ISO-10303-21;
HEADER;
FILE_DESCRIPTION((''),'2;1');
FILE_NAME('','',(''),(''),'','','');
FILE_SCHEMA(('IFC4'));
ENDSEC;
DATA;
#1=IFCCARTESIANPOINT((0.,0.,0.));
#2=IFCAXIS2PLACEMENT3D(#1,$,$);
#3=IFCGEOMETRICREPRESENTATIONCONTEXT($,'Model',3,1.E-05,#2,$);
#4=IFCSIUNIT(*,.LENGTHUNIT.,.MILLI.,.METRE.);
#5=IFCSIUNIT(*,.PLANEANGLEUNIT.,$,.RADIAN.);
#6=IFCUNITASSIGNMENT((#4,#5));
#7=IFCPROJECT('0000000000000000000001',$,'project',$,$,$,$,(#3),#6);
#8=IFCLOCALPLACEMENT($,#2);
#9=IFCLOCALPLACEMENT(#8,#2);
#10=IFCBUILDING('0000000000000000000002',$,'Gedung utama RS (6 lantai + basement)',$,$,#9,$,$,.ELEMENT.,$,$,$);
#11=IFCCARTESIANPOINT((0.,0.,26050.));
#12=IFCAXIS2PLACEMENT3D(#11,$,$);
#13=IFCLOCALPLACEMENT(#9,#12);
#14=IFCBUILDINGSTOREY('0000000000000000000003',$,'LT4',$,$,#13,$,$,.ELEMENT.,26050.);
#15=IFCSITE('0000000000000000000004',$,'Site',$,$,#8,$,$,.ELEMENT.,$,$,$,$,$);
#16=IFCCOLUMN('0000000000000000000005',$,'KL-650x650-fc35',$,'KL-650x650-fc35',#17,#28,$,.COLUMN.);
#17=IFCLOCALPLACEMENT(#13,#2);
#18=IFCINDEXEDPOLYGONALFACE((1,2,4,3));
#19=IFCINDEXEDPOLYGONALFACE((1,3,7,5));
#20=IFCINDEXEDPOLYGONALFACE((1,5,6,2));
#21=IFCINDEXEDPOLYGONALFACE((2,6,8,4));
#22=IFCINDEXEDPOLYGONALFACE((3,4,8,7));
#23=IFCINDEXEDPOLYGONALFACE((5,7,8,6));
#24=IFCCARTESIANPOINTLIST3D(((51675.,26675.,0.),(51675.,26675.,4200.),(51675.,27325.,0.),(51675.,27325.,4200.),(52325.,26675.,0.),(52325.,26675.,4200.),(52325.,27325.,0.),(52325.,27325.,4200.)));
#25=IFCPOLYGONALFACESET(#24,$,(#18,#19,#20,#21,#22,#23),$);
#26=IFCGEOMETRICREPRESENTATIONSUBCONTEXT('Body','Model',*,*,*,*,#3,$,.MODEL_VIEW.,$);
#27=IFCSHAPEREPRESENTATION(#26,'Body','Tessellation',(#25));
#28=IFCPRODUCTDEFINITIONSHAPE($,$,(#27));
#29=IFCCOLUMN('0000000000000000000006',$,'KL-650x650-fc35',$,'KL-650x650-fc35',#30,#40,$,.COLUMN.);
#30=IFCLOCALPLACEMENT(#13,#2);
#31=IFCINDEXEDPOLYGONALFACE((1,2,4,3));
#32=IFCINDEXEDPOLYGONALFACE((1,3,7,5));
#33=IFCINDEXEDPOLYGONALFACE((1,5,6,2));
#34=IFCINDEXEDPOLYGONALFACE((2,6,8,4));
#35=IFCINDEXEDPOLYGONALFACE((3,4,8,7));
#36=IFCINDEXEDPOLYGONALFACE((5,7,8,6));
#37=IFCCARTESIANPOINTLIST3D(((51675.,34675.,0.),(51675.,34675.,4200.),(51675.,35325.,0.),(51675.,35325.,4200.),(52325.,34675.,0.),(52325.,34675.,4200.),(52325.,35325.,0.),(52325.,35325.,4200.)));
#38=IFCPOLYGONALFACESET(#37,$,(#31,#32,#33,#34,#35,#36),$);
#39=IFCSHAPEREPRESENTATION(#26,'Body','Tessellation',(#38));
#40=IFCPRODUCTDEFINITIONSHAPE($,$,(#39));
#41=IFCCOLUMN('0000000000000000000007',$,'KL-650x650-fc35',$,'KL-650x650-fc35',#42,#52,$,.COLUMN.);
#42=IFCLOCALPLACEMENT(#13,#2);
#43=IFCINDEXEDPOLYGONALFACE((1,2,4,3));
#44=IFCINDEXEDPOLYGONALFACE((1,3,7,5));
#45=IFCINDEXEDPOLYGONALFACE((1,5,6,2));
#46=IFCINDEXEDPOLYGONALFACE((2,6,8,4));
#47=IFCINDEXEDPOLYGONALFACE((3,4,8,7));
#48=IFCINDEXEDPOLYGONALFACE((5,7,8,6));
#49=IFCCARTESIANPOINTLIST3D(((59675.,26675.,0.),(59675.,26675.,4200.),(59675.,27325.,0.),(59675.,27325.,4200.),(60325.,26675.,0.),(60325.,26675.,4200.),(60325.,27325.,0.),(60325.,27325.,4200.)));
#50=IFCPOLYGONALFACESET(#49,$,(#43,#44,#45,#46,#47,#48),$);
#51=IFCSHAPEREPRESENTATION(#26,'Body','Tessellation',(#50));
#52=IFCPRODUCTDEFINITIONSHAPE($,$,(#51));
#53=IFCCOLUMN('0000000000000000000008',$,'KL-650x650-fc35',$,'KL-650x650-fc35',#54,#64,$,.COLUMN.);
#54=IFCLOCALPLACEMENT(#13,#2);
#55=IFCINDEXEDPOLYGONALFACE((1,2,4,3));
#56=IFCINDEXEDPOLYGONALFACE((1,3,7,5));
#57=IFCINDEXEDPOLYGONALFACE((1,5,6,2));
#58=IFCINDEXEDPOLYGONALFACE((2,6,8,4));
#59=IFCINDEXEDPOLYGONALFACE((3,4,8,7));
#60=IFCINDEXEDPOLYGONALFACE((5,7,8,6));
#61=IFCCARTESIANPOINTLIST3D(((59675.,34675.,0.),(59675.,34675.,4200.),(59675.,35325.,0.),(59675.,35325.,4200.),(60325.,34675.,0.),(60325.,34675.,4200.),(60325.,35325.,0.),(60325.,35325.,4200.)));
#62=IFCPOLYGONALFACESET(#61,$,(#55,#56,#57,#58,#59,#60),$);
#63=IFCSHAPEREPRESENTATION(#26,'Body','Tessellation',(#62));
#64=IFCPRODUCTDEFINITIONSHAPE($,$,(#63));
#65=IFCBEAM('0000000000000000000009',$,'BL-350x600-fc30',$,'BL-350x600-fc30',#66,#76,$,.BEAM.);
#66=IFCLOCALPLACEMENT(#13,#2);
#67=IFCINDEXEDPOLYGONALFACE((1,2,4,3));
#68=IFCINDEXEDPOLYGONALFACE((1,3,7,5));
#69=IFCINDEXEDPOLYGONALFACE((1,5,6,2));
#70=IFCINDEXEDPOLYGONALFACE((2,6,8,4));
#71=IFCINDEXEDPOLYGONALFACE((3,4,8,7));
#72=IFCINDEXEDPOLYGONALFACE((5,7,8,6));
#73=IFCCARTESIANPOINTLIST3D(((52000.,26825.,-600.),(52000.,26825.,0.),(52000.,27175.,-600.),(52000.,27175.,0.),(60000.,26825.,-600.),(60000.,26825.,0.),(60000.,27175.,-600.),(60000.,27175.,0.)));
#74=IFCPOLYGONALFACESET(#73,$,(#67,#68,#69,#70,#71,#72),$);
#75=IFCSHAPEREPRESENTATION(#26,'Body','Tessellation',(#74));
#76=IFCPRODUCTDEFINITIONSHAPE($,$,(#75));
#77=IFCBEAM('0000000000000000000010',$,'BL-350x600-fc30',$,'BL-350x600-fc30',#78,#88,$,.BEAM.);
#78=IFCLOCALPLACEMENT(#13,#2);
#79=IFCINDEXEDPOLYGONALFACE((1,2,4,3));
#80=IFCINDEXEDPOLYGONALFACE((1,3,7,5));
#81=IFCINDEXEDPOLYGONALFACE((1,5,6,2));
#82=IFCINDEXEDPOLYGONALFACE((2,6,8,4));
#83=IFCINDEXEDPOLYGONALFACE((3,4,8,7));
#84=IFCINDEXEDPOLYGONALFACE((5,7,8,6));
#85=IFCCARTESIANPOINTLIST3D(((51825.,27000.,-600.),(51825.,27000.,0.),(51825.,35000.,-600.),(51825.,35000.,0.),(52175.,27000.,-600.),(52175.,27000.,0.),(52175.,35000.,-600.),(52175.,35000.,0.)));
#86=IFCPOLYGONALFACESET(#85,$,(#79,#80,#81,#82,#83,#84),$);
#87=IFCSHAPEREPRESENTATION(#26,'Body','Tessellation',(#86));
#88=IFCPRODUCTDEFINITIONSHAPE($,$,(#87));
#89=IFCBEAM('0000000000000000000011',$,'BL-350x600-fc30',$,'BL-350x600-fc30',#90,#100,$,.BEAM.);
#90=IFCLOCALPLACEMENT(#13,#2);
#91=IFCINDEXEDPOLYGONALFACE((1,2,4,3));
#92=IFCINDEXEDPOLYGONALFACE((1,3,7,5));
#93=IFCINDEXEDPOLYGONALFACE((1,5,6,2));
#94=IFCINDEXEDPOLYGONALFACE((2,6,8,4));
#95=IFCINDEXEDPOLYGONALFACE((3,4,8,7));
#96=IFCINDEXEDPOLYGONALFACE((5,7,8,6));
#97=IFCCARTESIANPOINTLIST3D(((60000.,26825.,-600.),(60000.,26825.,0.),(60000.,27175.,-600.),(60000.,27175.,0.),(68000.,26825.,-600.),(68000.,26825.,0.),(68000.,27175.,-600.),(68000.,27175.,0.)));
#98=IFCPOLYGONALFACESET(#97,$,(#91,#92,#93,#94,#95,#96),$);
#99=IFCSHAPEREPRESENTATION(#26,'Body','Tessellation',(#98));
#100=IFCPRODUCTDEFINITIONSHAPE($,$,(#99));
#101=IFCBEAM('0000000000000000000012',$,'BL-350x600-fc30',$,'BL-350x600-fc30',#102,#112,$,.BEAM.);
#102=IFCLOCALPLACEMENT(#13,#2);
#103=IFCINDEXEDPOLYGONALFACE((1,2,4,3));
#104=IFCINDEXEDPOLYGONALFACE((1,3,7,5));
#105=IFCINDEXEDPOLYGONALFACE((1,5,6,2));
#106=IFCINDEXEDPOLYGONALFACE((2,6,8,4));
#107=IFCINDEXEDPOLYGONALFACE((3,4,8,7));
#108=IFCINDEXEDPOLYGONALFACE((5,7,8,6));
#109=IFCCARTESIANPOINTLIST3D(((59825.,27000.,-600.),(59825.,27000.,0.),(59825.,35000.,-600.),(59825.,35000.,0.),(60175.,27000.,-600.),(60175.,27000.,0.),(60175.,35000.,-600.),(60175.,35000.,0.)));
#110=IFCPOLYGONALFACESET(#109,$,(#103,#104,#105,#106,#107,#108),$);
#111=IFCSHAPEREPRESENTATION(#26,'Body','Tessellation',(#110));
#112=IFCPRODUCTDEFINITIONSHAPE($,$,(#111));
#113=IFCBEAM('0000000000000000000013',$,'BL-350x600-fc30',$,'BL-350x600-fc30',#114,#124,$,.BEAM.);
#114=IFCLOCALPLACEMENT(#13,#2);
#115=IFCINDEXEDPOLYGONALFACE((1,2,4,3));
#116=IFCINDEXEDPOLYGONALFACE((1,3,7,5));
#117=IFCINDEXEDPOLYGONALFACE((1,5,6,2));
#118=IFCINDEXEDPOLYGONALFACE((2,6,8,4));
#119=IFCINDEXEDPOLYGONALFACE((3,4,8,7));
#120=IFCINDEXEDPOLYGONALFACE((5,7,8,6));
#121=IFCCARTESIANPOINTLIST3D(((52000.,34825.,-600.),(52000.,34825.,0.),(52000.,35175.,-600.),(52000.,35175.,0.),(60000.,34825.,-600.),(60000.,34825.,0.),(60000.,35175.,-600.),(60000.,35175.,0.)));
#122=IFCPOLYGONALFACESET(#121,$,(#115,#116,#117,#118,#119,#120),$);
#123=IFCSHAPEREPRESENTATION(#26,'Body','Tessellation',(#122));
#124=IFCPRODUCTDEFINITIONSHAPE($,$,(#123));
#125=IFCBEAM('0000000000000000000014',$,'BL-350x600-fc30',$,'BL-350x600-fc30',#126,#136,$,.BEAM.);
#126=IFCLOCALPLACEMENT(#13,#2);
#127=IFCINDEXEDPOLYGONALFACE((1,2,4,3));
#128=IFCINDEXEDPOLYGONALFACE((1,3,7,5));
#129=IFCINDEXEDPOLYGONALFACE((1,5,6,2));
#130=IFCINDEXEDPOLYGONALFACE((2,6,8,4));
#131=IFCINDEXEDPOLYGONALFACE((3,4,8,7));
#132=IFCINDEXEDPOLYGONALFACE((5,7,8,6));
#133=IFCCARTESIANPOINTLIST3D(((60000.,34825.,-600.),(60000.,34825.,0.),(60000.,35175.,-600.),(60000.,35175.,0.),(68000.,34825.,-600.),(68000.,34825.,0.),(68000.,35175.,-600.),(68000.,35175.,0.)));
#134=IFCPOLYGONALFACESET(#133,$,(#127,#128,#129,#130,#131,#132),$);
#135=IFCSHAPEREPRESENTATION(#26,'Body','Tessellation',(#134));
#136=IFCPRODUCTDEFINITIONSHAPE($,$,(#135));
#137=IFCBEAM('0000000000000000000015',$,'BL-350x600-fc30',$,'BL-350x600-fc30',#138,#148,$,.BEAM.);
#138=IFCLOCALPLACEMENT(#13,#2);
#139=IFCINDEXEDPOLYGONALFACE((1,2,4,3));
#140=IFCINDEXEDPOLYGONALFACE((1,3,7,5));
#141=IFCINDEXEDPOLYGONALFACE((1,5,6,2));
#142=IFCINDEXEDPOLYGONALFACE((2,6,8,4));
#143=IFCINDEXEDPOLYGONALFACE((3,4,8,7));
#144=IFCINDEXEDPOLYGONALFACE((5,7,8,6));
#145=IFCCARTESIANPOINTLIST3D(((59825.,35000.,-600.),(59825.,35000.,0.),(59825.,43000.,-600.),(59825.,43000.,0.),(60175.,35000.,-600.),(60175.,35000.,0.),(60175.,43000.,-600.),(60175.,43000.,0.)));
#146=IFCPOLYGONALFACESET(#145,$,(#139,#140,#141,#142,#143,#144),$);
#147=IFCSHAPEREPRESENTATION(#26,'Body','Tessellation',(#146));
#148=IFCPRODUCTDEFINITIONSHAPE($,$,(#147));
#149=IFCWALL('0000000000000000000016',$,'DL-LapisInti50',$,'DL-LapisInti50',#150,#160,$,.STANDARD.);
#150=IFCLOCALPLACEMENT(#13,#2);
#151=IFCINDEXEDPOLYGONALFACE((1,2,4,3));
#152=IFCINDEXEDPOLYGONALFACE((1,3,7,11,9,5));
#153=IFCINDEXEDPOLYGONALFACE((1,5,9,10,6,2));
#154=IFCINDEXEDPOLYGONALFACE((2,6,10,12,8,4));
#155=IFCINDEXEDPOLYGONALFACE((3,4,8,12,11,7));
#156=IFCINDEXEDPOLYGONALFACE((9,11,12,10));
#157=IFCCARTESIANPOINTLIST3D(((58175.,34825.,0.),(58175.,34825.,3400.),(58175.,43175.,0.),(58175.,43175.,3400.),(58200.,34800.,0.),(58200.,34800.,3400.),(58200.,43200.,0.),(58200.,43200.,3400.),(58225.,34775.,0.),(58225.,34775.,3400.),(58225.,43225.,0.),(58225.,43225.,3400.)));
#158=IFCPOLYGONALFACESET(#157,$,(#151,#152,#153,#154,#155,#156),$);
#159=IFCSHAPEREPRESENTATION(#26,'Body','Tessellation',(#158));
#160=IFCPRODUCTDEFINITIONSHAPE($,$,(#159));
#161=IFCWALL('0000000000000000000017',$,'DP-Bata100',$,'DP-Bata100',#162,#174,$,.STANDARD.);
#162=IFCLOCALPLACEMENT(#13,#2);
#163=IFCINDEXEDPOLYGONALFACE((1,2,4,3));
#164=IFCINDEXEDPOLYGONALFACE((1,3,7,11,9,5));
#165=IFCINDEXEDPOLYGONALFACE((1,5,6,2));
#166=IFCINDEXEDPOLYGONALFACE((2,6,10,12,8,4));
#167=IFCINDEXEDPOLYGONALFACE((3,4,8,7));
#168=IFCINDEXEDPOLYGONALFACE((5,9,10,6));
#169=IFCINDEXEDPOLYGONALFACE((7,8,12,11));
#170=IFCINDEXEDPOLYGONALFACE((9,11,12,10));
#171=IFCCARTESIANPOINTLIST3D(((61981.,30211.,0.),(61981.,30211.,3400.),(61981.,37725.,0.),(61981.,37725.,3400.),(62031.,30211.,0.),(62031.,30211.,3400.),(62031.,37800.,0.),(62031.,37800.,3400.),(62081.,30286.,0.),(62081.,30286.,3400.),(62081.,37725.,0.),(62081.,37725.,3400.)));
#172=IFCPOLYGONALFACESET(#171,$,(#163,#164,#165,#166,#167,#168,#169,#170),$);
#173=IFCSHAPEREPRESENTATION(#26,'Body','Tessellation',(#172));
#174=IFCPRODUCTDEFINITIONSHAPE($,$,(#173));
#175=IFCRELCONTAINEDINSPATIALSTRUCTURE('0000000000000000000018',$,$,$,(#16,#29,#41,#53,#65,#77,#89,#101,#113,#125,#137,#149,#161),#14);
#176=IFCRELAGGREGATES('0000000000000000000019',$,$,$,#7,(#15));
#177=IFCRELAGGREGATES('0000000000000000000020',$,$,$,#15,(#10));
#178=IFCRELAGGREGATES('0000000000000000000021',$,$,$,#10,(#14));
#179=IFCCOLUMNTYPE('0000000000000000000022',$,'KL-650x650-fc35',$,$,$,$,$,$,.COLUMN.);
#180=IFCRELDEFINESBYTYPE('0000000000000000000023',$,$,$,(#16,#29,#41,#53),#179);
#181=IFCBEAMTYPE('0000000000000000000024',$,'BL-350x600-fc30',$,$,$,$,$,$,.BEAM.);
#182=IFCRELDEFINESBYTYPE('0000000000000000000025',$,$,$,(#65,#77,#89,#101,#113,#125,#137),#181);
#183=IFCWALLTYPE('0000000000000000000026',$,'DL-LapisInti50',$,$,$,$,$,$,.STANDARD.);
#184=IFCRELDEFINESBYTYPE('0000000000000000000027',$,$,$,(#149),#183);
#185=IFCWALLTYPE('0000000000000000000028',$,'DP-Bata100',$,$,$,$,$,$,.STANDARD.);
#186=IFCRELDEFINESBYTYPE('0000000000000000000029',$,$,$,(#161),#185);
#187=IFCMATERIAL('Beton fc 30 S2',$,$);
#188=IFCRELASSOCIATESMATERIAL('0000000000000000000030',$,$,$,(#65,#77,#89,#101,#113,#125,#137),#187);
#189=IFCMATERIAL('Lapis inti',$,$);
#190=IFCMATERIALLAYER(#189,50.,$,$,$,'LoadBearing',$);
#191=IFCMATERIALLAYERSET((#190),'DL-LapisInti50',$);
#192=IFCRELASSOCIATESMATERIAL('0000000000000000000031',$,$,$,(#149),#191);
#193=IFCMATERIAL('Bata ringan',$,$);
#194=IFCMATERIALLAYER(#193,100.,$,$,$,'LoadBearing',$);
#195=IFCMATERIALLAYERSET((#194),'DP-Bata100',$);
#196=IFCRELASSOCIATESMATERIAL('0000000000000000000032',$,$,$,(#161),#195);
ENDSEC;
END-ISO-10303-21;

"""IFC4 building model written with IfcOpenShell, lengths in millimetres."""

from ifc_helpers import new_model, si_unit, frame, origin, origin_2d, place, context, subcontext, project, spatial, polyline, rectangle, outline, extrude, material, layer, layer_set, layer_usage, material_profile, profile_set, profile_usage, type_object, element, save


model = new_model("IFC4")

# Units and contexts
model_context = context("Model", 3, precision=1e-05, world=origin())
body_context = subcontext(model_context, "Body", "Model", "MODEL_VIEW")
ifc_project = project(units=[si_unit("LENGTHUNIT", "METRE", prefix="MILLI"), si_unit("PLANEANGLEUNIT", "RADIAN")], contexts=[model_context])

# Site, building, storey
site_placement = place(None, origin())
site = spatial("IfcSite", under=ifc_project, at=site_placement, Name="Site", CompositionType="ELEMENT")
building_placement = place(site_placement, origin())
building = spatial("IfcBuilding", under=site, at=building_placement, Name="Gedung utama RS (6 lantai + basement)", CompositionType="ELEMENT")
storey_placement = place(building_placement, frame((0.0, 0.0, 26050.0)))
storey = spatial("IfcBuildingStorey", under=building, at=storey_placement, Name="LT4", CompositionType="ELEMENT", Elevation=26050.0)

# Columns
ifc_material_profile_1 = material_profile(None, rectangle(XDim=650.0, YDim=650.0, at=origin_2d()), Name="KL-650x650-fc35")
ifc_profile_set_1 = profile_set([ifc_material_profile_1], Name="KL-650x650-fc35")
ifc_profile_usage_1 = profile_usage(ifc_profile_set_1, cardinal=5)
column_type = type_object("IfcColumnType", Name="KL-650x650-fc35", PredefinedType="COLUMN")
for number, where, z_axis, x_axis, name in (
    (1, (52000.0, 27000.0, 0.0), (0.0, 0.0, 1.0), (1.0, 0.0, 0.0), "KL-650x650-fc35"),
    (2, (52000.0, 35000.0, 0.0), (0.0, 0.0, 1.0), (1.0, 0.0, 0.0), "KL-650x650-fc35"),
    (3, (60000.0, 27000.0, 0.0), (0.0, 0.0, 1.0), (1.0, 0.0, 0.0), "KL-650x650-fc35"),
    (4, (60000.0, 35000.0, 0.0), (0.0, 0.0, 1.0), (1.0, 0.0, 0.0), "KL-650x650-fc35"),
):
    element("IfcColumn", number, at=place(storey_placement, frame(where, z_axis=z_axis, x_axis=x_axis)), inside=storey, type_object=column_type, material=ifc_profile_usage_1, Name=name, ObjectType="KL-650x650-fc35", PredefinedType="COLUMN", context=body_context, shape_type="SweptSolid", body=[
        extrude(rectangle(XDim=650.0, YDim=650.0, at=origin_2d()), origin(), (0.0, 0.0, 1.0), 4200.0),
    ])

# Beams
ifc_material_1 = material(Name="Beton fc 30 S2")
ifc_material_profile_2 = material_profile(ifc_material_1, rectangle(XDim=350.0, YDim=600.0, at=origin_2d()), Name="BL-350x600-fc30")
ifc_profile_set_2 = profile_set([ifc_material_profile_2], Name="BL-350x600-fc30")
ifc_profile_usage_2 = profile_usage(ifc_profile_set_2, cardinal=8)
beam_type = type_object("IfcBeamType", Name="BL-350x600-fc30", PredefinedType="BEAM")
beam_1_placement = place(storey_placement, frame((52000.0, 27000.0, -300.0)))
element("IfcBeam", 5, at=beam_1_placement, inside=storey, type_object=beam_type, material=ifc_profile_usage_2, Name="BL-350x600-fc30", ObjectType="BL-350x600-fc30", PredefinedType="BEAM", context=body_context, shape_type="SweptSolid", body=[
    extrude(rectangle(XDim=350.0, YDim=600.0, at=origin_2d()), frame((0.0, 0.0, 0.0), z_axis=(1.0, 0.0, 0.0), x_axis=(0.0, 1.0, 0.0)), (0.0, 0.0, 1.0), 8000.0),
])
beam_2_placement = place(storey_placement, frame((52000.0, 27000.0, -300.0)))
element("IfcBeam", 6, at=beam_2_placement, inside=storey, type_object=beam_type, material=ifc_profile_usage_2, Name="BL-350x600-fc30", ObjectType="BL-350x600-fc30", PredefinedType="BEAM", context=body_context, shape_type="SweptSolid", body=[
    extrude(rectangle(XDim=350.0, YDim=600.0, at=origin_2d()), frame((0.0, 0.0, 0.0), z_axis=(0.0, 1.0, 0.0), x_axis=(-1.0, 0.0, 0.0)), (0.0, 0.0, 1.0), 8000.0),
])
beam_3_placement = place(storey_placement, frame((60000.0, 27000.0, -300.0)))
element("IfcBeam", 7, at=beam_3_placement, inside=storey, type_object=beam_type, material=ifc_profile_usage_2, Name="BL-350x600-fc30", ObjectType="BL-350x600-fc30", PredefinedType="BEAM", context=body_context, shape_type="SweptSolid", body=[
    extrude(rectangle(XDim=350.0, YDim=600.0, at=origin_2d()), frame((0.0, 0.0, 0.0), z_axis=(1.0, 0.0, 0.0), x_axis=(0.0, 1.0, 0.0)), (0.0, 0.0, 1.0), 8000.0),
])
beam_4_placement = place(storey_placement, frame((60000.0, 27000.0, -300.0)))
element("IfcBeam", 8, at=beam_4_placement, inside=storey, type_object=beam_type, material=ifc_profile_usage_2, Name="BL-350x600-fc30", ObjectType="BL-350x600-fc30", PredefinedType="BEAM", context=body_context, shape_type="SweptSolid", body=[
    extrude(rectangle(XDim=350.0, YDim=600.0, at=origin_2d()), frame((0.0, 0.0, 0.0), z_axis=(0.0, 1.0, 0.0), x_axis=(-1.0, 0.0, 0.0)), (0.0, 0.0, 1.0), 8000.0),
])
for number, where, name in (
    (9, (52000.0, 35000.0, -300.0), "BL-350x600-fc30"),
    (10, (60000.0, 35000.0, -300.0), "BL-350x600-fc30"),
):
    element("IfcBeam", number, at=place(storey_placement, frame(where)), inside=storey, type_object=beam_type, material=ifc_profile_usage_2, Name=name, ObjectType="BL-350x600-fc30", PredefinedType="BEAM", context=body_context, shape_type="SweptSolid", body=[
        extrude(rectangle(XDim=350.0, YDim=600.0, at=origin_2d()), frame((0.0, 0.0, 0.0), z_axis=(1.0, 0.0, 0.0), x_axis=(0.0, 1.0, 0.0)), (0.0, 0.0, 1.0), 8000.0),
    ])
beam_5_placement = place(storey_placement, frame((60000.0, 35000.0, -300.0)))
element("IfcBeam", 11, at=beam_5_placement, inside=storey, type_object=beam_type, material=ifc_profile_usage_2, Name="BL-350x600-fc30", ObjectType="BL-350x600-fc30", PredefinedType="BEAM", context=body_context, shape_type="SweptSolid", body=[
    extrude(rectangle(XDim=350.0, YDim=600.0, at=origin_2d()), frame((0.0, 0.0, 0.0), z_axis=(0.0, 1.0, 0.0), x_axis=(-1.0, 0.0, 0.0)), (0.0, 0.0, 1.0), 8000.0),
])

# Walls
ifc_material_2 = material(Name="Lapis inti")
ifc_layer_1 = layer(ifc_material_2, 50.0, Category="LoadBearing")
ifc_layer_set_1 = layer_set([ifc_layer_1], Name="DL-LapisInti50")
ifc_layer_usage_1 = layer_usage(ifc_layer_set_1, "AXIS2", "NEGATIVE", 25.0)
wall_type_1 = type_object("IfcWallType", Name="DL-LapisInti50", PredefinedType="STANDARD")
wall_1_placement = place(storey_placement, frame((58200.0, 34800.0, 0.0), z_axis=(0.0, 0.0, 1.0), x_axis=(0.0, 1.0, 0.0)))
element("IfcWall", 12, at=wall_1_placement, inside=storey, type_object=wall_type_1, material=ifc_layer_usage_1, Name="DL-LapisInti50", ObjectType="DL-LapisInti50", PredefinedType="STANDARD", context=body_context, shape_type="SweptSolid", body=[
    extrude(outline(polyline([(-25.0, -25.0), (0.0, 0.0), (25.0, 25.0), (8375.0, 25.0), (8400.0, 0.0), (8425.0, -25.0), (-25.0, -25.0)])), origin(), (0.0, 0.0, 1.0), 3400.0),
])
ifc_material_3 = material(Name="Bata ringan")
ifc_layer_2 = layer(ifc_material_3, 100.0, Category="LoadBearing")
ifc_layer_set_2 = layer_set([ifc_layer_2], Name="DP-Bata100")
ifc_layer_usage_2 = layer_usage(ifc_layer_set_2, "AXIS2", "NEGATIVE", 50.0)
wall_type_2 = type_object("IfcWallType", Name="DP-Bata100", PredefinedType="STANDARD")
wall_2_placement = place(storey_placement, frame((62031.0, 37800.0, 0.0), z_axis=(0.0, 0.0, 1.0), x_axis=(0.0, -1.0, 0.0)))
element("IfcWall", 13, at=wall_2_placement, inside=storey, type_object=wall_type_2, material=ifc_layer_usage_2, Name="DP-Bata100", ObjectType="DP-Bata100", PredefinedType="STANDARD", context=body_context, shape_type="SweptSolid", body=[
    extrude(outline(polyline([(75.0, -50.0), (0.0, 0.0), (75.0, 50.0), (7514.0, 50.0), (7589.0, 0.0), (7589.0, -50.0), (75.0, -50.0)])), origin(), (0.0, 0.0, 1.0), 3400.0),
])

save(model, "model.ifc")
